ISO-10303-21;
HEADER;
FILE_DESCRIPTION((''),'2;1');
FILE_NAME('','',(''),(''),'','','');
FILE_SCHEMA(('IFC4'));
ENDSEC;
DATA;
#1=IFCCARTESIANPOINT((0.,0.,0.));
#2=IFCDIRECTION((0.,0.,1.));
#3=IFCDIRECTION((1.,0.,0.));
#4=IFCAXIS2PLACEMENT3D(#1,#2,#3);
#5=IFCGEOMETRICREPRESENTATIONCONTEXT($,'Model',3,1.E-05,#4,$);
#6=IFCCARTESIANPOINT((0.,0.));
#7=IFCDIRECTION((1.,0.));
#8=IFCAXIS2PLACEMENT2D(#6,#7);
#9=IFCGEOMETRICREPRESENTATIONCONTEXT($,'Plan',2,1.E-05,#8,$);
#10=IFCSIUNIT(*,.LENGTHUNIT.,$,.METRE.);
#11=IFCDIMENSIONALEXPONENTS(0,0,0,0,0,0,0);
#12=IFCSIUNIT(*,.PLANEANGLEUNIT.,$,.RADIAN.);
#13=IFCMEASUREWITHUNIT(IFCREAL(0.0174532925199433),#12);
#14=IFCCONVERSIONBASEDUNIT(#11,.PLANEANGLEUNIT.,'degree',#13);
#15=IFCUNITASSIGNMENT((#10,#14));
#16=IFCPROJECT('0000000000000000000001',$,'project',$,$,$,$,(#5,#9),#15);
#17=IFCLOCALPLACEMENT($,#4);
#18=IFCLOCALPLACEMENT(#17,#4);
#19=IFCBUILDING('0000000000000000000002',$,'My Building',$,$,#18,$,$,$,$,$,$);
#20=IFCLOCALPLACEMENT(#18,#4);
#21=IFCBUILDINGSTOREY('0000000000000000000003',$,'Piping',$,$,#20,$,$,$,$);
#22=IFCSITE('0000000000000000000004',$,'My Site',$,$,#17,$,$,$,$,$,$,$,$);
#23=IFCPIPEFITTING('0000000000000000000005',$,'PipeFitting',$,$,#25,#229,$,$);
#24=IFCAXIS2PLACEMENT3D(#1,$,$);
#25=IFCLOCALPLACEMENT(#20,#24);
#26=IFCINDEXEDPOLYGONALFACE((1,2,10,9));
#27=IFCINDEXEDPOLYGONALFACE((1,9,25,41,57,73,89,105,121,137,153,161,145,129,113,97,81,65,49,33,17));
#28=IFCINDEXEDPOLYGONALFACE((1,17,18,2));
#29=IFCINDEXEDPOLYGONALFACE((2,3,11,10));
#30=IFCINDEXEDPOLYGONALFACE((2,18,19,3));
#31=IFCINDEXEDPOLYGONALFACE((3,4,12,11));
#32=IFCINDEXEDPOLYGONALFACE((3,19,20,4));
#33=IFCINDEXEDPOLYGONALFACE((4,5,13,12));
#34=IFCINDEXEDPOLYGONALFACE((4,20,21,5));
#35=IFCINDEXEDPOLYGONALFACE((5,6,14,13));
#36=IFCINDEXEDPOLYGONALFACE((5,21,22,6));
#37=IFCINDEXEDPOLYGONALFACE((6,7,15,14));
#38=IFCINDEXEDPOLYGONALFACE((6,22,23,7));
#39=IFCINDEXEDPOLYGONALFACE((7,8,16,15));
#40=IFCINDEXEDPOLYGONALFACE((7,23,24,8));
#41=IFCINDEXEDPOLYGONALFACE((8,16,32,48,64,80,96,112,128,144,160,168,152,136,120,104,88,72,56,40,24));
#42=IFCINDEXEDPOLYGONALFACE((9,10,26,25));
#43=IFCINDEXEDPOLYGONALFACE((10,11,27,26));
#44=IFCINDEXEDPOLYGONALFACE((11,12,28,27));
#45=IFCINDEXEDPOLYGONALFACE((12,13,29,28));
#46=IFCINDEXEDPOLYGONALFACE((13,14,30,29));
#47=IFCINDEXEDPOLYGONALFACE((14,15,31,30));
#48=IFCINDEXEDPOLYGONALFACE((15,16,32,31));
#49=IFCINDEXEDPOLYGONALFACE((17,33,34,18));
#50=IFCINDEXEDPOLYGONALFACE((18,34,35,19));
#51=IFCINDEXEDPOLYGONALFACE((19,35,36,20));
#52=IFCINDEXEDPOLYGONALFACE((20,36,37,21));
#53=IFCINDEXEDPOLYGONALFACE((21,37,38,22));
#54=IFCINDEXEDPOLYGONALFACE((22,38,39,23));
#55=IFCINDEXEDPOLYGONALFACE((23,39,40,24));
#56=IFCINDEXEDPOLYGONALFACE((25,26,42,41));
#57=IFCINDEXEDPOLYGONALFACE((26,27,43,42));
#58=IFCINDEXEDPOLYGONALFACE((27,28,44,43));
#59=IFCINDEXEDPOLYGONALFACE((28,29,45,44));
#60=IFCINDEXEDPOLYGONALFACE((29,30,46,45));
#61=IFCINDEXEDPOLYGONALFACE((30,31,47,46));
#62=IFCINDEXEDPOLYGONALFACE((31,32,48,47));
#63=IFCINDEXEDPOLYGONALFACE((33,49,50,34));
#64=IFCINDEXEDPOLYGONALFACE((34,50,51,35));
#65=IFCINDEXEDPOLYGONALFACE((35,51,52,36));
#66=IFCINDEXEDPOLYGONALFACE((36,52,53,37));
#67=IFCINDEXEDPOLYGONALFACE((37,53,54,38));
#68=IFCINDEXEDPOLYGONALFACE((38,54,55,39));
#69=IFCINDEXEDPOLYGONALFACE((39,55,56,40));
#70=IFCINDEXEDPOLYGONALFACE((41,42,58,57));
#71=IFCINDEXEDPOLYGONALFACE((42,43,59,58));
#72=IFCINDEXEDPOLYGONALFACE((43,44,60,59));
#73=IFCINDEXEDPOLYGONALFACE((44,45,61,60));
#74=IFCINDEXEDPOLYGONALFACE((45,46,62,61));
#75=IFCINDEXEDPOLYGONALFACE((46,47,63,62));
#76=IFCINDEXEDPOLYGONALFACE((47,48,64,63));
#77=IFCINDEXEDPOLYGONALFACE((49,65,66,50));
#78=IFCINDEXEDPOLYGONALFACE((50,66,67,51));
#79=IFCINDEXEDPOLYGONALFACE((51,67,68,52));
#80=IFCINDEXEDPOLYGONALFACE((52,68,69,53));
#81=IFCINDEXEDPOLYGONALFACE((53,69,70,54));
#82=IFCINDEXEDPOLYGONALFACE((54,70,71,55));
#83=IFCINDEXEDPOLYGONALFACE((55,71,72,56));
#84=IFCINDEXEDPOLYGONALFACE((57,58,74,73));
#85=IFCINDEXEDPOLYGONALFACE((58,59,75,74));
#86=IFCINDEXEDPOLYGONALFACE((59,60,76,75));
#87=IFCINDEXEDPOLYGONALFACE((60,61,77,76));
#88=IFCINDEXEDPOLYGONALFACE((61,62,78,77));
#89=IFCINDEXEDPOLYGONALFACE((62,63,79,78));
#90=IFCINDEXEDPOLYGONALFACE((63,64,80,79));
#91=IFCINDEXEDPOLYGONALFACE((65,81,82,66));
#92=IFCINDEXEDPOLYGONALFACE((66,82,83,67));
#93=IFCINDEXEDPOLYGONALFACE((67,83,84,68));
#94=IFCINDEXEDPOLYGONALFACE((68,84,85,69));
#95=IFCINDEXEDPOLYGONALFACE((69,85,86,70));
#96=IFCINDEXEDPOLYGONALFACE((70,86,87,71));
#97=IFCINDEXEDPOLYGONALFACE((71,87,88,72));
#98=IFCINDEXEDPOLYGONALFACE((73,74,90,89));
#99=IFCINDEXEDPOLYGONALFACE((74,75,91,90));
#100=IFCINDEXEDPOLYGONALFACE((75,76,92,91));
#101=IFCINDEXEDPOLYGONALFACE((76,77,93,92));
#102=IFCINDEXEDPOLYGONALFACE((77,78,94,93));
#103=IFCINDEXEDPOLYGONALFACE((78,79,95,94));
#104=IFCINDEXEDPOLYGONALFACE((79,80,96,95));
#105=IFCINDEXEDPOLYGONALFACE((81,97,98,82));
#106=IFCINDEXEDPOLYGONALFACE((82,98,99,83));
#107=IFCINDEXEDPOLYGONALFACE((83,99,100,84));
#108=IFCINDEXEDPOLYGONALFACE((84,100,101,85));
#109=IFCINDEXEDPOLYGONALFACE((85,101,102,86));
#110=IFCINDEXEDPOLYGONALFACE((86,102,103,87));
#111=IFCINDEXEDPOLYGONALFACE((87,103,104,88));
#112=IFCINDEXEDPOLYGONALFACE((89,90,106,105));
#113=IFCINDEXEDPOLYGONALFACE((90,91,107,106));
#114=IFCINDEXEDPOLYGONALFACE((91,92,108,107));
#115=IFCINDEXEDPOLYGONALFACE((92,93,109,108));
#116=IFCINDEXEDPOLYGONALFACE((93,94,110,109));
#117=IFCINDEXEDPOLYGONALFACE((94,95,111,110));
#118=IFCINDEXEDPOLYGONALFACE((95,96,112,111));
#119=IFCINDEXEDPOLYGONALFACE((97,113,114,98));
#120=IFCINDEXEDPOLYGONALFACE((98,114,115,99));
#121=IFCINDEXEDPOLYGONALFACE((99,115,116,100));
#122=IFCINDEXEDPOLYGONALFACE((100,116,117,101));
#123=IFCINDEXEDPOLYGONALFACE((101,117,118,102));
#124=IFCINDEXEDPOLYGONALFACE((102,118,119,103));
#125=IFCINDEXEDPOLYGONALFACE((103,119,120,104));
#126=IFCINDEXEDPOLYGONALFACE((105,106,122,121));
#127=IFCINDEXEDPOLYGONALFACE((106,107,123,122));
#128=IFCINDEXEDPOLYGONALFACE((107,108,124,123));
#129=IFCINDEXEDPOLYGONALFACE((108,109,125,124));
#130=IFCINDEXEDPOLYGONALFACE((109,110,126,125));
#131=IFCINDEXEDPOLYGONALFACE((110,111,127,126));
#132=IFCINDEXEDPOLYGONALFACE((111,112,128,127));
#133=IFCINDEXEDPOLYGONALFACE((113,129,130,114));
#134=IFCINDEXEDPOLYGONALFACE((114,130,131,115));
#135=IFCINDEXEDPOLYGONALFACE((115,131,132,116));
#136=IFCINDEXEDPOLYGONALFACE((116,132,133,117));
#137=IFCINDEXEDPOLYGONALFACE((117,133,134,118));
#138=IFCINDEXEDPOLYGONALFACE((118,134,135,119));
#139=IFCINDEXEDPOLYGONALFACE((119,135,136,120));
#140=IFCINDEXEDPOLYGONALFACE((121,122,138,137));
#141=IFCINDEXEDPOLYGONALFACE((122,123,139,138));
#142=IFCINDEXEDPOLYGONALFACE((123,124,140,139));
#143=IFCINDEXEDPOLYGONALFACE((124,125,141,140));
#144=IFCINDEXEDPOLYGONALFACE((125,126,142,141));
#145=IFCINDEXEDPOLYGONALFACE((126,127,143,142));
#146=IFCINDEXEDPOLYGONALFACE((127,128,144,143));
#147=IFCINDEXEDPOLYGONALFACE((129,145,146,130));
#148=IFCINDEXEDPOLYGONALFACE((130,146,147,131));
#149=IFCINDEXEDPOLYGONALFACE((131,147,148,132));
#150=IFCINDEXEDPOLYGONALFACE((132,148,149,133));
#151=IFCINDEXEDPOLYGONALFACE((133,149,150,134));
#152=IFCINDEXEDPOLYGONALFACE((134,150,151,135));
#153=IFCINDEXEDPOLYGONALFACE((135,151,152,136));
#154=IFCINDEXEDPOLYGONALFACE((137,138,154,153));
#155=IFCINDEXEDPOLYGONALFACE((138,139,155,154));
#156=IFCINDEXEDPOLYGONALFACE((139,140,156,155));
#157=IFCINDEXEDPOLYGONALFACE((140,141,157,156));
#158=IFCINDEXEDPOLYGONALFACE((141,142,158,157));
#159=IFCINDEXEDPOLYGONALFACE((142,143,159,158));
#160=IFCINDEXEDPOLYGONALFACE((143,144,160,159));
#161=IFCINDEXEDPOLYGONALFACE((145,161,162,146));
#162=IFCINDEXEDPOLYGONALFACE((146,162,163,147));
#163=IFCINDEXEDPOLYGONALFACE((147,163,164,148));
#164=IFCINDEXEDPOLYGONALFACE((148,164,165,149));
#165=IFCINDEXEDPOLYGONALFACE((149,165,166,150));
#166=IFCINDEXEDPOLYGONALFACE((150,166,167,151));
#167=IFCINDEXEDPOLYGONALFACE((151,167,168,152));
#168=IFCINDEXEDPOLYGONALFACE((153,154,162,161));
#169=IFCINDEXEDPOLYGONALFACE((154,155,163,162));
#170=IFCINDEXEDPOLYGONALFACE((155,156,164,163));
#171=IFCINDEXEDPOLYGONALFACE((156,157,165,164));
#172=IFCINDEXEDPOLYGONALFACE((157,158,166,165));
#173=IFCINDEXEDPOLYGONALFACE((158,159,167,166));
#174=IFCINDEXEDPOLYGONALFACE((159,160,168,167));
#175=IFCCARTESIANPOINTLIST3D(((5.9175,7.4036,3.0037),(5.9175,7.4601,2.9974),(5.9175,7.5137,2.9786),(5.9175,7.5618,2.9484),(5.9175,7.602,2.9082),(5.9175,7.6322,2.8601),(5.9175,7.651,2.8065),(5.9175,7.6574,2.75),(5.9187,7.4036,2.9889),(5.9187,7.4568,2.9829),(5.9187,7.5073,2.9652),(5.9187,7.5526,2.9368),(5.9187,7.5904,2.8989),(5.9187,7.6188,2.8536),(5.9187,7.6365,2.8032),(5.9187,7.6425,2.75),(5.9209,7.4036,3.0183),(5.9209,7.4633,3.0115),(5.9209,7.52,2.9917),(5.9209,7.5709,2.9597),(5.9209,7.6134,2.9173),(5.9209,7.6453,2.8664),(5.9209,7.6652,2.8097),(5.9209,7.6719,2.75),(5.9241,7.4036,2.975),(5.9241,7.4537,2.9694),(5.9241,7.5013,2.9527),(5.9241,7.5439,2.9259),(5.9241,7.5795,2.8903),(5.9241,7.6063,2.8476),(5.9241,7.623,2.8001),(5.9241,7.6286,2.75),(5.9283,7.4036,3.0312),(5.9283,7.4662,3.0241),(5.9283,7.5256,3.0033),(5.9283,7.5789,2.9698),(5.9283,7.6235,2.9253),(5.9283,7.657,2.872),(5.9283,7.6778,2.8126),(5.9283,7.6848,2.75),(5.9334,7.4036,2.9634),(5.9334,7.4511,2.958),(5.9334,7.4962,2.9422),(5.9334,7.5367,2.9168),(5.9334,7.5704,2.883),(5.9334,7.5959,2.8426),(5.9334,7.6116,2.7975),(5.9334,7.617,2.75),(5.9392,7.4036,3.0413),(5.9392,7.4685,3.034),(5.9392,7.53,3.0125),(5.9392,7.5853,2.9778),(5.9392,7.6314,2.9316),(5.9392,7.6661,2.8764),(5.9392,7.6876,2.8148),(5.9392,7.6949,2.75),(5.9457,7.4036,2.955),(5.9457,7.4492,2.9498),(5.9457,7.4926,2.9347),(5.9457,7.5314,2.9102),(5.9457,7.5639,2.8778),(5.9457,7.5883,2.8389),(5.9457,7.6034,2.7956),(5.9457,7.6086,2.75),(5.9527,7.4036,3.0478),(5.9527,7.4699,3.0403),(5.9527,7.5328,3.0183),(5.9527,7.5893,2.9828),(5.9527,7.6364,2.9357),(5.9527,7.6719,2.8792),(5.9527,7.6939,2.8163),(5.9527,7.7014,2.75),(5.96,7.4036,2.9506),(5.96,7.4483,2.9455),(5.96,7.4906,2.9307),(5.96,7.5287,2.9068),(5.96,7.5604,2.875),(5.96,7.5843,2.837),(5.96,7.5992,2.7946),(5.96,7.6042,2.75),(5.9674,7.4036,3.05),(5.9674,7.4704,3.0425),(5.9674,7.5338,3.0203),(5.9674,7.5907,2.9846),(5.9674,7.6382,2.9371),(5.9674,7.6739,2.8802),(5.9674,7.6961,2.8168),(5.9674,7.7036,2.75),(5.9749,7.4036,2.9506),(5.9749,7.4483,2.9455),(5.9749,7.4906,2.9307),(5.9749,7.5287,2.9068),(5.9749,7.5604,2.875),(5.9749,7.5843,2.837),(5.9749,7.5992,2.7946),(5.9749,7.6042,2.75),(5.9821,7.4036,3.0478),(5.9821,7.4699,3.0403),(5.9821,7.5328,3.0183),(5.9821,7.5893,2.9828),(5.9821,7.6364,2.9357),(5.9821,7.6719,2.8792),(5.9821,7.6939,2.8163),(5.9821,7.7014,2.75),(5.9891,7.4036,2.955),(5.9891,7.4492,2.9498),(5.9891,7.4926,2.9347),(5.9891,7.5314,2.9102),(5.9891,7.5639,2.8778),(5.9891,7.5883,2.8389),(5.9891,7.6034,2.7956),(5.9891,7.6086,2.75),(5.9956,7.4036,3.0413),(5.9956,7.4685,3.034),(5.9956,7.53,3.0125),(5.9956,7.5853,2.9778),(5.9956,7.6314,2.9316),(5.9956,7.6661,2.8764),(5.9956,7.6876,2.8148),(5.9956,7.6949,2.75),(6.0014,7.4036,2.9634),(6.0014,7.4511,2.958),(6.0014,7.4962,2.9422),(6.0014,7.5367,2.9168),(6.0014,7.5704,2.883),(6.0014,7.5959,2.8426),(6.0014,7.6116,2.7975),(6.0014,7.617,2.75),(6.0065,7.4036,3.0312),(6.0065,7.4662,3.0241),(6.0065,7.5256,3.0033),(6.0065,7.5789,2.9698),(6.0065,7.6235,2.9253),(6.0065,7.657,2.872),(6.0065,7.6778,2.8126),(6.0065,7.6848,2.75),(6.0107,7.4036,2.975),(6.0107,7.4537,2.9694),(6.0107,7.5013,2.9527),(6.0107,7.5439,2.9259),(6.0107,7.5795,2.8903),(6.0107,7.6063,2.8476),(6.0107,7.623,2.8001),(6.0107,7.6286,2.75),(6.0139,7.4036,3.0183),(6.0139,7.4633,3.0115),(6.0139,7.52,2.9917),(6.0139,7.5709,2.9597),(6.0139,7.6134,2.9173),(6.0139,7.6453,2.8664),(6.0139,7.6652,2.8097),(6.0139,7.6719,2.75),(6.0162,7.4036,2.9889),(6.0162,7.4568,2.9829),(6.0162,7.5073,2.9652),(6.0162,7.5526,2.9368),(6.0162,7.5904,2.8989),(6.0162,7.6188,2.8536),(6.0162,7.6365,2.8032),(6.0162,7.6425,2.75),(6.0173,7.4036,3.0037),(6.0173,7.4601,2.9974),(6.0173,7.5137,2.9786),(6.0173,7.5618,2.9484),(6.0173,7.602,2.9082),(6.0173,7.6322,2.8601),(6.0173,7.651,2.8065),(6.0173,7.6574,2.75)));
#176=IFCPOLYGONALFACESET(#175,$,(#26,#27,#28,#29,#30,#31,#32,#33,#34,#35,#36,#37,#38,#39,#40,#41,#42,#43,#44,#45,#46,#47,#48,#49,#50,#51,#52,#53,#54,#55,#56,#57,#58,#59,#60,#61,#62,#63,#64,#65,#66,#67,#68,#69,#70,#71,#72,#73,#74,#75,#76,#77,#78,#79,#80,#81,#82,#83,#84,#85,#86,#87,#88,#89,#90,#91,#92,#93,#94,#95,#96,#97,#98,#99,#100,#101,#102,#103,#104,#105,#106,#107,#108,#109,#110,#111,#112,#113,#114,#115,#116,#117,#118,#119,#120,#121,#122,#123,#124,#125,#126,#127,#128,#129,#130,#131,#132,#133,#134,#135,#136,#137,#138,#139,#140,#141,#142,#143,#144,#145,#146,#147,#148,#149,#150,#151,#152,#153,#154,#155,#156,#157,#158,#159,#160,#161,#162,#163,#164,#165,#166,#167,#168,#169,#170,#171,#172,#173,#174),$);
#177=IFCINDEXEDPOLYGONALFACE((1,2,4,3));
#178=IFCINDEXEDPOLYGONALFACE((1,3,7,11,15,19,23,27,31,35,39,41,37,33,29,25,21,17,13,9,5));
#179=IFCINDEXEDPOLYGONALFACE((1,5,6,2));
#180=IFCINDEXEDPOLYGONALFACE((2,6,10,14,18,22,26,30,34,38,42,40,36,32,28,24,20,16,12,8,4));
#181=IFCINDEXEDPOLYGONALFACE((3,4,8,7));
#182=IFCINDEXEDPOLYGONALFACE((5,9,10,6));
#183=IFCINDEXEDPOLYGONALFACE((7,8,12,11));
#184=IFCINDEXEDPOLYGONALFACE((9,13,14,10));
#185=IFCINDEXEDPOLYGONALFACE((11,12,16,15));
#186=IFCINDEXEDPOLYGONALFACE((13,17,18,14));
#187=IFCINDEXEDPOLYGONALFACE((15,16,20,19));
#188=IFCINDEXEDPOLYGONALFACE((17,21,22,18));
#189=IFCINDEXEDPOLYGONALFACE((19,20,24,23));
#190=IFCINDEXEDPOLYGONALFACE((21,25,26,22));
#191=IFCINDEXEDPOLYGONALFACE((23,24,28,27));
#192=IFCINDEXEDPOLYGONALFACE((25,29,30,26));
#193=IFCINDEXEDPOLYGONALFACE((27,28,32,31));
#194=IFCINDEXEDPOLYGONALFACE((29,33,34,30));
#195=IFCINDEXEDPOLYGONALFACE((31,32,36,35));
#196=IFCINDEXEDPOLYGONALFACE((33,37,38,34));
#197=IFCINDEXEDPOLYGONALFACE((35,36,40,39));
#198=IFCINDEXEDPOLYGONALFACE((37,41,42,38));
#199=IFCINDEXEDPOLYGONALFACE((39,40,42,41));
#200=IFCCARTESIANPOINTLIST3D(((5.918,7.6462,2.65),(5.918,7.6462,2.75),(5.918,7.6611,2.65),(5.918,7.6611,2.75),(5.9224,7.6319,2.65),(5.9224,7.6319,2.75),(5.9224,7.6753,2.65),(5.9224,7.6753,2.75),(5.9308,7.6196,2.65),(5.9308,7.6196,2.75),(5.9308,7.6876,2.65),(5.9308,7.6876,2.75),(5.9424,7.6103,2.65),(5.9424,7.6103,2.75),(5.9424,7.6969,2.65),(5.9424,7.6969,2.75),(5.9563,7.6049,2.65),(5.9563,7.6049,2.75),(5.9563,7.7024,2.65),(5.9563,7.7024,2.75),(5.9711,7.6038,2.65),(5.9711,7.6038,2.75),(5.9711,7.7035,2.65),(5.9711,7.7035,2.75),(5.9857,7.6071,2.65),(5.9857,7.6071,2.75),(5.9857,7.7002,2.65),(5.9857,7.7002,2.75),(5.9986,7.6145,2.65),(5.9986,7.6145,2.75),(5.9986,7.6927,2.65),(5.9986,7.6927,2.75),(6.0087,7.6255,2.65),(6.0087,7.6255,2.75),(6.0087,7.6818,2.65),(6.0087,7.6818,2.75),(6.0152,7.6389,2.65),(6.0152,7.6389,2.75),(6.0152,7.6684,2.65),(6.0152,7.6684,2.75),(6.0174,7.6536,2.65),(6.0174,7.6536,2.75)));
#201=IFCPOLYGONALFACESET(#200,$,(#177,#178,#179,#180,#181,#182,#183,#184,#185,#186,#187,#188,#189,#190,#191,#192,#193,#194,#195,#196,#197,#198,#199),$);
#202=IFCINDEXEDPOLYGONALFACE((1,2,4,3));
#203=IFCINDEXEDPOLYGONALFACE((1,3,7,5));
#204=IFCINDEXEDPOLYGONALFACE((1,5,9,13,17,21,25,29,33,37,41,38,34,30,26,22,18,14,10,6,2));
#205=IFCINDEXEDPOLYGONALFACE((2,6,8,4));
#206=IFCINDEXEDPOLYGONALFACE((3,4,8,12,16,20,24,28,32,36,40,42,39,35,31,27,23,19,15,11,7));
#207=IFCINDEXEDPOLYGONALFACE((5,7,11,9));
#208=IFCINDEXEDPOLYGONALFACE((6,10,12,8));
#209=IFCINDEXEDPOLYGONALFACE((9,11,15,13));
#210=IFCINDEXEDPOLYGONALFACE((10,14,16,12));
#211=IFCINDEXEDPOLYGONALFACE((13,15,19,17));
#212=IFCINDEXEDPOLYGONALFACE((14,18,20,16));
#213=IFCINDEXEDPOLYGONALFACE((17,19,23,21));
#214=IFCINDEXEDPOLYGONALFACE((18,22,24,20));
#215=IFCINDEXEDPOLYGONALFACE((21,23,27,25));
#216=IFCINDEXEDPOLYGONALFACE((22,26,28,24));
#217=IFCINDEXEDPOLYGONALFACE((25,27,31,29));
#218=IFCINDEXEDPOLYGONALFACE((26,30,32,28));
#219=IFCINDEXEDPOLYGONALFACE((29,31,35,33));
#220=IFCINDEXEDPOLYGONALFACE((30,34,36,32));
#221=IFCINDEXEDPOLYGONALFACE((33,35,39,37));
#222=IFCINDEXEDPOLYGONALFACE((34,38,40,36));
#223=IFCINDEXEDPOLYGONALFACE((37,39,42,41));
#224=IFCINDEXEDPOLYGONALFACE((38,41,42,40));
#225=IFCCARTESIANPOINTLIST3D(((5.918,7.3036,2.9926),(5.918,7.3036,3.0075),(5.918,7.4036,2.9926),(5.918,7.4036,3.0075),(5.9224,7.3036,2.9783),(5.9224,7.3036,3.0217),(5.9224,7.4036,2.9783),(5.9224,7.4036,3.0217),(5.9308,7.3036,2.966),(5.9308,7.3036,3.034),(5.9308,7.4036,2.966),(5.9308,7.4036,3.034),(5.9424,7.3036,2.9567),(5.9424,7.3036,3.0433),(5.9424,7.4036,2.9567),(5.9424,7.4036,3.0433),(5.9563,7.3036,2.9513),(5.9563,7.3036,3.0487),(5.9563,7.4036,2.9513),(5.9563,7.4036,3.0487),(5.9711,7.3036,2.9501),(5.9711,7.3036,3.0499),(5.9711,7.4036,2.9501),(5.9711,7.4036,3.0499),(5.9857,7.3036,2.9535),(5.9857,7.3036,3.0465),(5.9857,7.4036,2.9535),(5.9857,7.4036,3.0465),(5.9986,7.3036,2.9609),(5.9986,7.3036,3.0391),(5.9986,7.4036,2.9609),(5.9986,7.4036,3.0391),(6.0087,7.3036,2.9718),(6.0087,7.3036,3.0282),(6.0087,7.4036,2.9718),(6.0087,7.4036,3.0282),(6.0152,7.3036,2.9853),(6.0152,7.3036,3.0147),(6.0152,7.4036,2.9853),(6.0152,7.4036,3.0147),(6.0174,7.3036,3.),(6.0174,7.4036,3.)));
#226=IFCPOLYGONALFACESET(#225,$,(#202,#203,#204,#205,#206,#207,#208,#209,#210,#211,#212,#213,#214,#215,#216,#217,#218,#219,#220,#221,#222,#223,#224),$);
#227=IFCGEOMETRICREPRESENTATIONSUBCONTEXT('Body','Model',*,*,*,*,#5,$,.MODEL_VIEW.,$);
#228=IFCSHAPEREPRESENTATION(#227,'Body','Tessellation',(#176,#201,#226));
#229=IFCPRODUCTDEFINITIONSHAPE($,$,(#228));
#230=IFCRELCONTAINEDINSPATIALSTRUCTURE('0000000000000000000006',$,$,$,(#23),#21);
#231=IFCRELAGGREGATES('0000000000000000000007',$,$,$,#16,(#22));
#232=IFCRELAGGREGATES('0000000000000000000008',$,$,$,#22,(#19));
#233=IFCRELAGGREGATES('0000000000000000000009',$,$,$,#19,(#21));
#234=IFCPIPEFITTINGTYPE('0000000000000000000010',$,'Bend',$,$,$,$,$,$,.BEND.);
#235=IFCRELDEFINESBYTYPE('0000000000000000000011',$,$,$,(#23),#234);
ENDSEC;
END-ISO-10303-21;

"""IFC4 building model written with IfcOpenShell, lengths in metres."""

from ifc_helpers import new_model, entity, si_unit, converted_unit, frame, origin_with_axes, origin_2d_with_axis, place, context, subcontext, project, spatial, circle, extrude, source, transform, mapped, type_object, type_shapes, element, save


model = new_model("IFC4")

# Units and contexts
model_context = context("Model", 3, precision=1e-05, world=origin_with_axes())
plan_context = context("Plan", 2, precision=1e-05, world=origin_2d_with_axis())
body_context = subcontext(model_context, "Body", "Model", "MODEL_VIEW")
ifc_project = project(units=[si_unit("LENGTHUNIT", "METRE"), converted_unit("PLANEANGLEUNIT", "degree", entity("IfcReal", 0.0174532925199433), si_unit("PLANEANGLEUNIT", "RADIAN"), dimensions=[0, 0, 0, 0, 0, 0, 0])], contexts=[model_context, plan_context])

# Site, building, storey
site_placement = place(None, origin_with_axes())
site = spatial("IfcSite", under=ifc_project, at=site_placement, Name="My Site")
building_placement = place(site_placement, origin_with_axes())
building = spatial("IfcBuilding", under=site, at=building_placement, Name="My Building")
storey_placement = place(building_placement, origin_with_axes())
storey = spatial("IfcBuildingStorey", under=building, at=storey_placement, Name="Piping")

# Pipe fitting
pipe_fitting_type = type_object("IfcPipeFittingType", Name="Bend", PredefinedType="BEND")
shared_shape = source(origin_with_axes(), body_context, "Body", "SolidModel", [
    entity("IfcSweptDiskSolid", entity("IfcIndexedPolyCurve", entity("IfcCartesianPointList3D", [[0.0, 0.0, -0.1], [0.0, 0.0732, -0.2768], [0.0, 0.25, -0.35]]), [entity("IfcArcIndex", [1, 2, 3])]), 0.05),
    extrude(circle(Radius=0.05), origin_with_axes(), (0.0, 0.0, -1.0), 0.1),
    extrude(circle(Radius=0.05), frame((0.0, 0.25, -0.35), z_axis=(0.0, 1.0, 0.0), x_axis=(1.0, 0.0, 0.0)), (0.0, 0.0, 1.0), 0.1),
])
type_shapes(pipe_fitting_type, [shared_shape])
for number, where, z_axis, x_axis, name in (
    (1, (5.9674, 7.6536, 2.65), (0.0, 0.0, -1.0), (1.0, 0.0, 0.0), "PipeFitting"),
):
    element("IfcPipeFitting", number, at=place(storey_placement, frame(where, z_axis=z_axis, x_axis=x_axis)), inside=storey, type_object=pipe_fitting_type, Name=name, context=body_context, shape_type="MappedRepresentation", body=[
        mapped(shared_shape, transform((0.0, 0.0, 0.0), x_axis=(1.0, 0.0, 0.0), y_axis=(0.0, 1.0, 0.0), z_axis=(0.0, 0.0, 1.0), scale=1.0)),
    ])

save(model, "model.ifc")
